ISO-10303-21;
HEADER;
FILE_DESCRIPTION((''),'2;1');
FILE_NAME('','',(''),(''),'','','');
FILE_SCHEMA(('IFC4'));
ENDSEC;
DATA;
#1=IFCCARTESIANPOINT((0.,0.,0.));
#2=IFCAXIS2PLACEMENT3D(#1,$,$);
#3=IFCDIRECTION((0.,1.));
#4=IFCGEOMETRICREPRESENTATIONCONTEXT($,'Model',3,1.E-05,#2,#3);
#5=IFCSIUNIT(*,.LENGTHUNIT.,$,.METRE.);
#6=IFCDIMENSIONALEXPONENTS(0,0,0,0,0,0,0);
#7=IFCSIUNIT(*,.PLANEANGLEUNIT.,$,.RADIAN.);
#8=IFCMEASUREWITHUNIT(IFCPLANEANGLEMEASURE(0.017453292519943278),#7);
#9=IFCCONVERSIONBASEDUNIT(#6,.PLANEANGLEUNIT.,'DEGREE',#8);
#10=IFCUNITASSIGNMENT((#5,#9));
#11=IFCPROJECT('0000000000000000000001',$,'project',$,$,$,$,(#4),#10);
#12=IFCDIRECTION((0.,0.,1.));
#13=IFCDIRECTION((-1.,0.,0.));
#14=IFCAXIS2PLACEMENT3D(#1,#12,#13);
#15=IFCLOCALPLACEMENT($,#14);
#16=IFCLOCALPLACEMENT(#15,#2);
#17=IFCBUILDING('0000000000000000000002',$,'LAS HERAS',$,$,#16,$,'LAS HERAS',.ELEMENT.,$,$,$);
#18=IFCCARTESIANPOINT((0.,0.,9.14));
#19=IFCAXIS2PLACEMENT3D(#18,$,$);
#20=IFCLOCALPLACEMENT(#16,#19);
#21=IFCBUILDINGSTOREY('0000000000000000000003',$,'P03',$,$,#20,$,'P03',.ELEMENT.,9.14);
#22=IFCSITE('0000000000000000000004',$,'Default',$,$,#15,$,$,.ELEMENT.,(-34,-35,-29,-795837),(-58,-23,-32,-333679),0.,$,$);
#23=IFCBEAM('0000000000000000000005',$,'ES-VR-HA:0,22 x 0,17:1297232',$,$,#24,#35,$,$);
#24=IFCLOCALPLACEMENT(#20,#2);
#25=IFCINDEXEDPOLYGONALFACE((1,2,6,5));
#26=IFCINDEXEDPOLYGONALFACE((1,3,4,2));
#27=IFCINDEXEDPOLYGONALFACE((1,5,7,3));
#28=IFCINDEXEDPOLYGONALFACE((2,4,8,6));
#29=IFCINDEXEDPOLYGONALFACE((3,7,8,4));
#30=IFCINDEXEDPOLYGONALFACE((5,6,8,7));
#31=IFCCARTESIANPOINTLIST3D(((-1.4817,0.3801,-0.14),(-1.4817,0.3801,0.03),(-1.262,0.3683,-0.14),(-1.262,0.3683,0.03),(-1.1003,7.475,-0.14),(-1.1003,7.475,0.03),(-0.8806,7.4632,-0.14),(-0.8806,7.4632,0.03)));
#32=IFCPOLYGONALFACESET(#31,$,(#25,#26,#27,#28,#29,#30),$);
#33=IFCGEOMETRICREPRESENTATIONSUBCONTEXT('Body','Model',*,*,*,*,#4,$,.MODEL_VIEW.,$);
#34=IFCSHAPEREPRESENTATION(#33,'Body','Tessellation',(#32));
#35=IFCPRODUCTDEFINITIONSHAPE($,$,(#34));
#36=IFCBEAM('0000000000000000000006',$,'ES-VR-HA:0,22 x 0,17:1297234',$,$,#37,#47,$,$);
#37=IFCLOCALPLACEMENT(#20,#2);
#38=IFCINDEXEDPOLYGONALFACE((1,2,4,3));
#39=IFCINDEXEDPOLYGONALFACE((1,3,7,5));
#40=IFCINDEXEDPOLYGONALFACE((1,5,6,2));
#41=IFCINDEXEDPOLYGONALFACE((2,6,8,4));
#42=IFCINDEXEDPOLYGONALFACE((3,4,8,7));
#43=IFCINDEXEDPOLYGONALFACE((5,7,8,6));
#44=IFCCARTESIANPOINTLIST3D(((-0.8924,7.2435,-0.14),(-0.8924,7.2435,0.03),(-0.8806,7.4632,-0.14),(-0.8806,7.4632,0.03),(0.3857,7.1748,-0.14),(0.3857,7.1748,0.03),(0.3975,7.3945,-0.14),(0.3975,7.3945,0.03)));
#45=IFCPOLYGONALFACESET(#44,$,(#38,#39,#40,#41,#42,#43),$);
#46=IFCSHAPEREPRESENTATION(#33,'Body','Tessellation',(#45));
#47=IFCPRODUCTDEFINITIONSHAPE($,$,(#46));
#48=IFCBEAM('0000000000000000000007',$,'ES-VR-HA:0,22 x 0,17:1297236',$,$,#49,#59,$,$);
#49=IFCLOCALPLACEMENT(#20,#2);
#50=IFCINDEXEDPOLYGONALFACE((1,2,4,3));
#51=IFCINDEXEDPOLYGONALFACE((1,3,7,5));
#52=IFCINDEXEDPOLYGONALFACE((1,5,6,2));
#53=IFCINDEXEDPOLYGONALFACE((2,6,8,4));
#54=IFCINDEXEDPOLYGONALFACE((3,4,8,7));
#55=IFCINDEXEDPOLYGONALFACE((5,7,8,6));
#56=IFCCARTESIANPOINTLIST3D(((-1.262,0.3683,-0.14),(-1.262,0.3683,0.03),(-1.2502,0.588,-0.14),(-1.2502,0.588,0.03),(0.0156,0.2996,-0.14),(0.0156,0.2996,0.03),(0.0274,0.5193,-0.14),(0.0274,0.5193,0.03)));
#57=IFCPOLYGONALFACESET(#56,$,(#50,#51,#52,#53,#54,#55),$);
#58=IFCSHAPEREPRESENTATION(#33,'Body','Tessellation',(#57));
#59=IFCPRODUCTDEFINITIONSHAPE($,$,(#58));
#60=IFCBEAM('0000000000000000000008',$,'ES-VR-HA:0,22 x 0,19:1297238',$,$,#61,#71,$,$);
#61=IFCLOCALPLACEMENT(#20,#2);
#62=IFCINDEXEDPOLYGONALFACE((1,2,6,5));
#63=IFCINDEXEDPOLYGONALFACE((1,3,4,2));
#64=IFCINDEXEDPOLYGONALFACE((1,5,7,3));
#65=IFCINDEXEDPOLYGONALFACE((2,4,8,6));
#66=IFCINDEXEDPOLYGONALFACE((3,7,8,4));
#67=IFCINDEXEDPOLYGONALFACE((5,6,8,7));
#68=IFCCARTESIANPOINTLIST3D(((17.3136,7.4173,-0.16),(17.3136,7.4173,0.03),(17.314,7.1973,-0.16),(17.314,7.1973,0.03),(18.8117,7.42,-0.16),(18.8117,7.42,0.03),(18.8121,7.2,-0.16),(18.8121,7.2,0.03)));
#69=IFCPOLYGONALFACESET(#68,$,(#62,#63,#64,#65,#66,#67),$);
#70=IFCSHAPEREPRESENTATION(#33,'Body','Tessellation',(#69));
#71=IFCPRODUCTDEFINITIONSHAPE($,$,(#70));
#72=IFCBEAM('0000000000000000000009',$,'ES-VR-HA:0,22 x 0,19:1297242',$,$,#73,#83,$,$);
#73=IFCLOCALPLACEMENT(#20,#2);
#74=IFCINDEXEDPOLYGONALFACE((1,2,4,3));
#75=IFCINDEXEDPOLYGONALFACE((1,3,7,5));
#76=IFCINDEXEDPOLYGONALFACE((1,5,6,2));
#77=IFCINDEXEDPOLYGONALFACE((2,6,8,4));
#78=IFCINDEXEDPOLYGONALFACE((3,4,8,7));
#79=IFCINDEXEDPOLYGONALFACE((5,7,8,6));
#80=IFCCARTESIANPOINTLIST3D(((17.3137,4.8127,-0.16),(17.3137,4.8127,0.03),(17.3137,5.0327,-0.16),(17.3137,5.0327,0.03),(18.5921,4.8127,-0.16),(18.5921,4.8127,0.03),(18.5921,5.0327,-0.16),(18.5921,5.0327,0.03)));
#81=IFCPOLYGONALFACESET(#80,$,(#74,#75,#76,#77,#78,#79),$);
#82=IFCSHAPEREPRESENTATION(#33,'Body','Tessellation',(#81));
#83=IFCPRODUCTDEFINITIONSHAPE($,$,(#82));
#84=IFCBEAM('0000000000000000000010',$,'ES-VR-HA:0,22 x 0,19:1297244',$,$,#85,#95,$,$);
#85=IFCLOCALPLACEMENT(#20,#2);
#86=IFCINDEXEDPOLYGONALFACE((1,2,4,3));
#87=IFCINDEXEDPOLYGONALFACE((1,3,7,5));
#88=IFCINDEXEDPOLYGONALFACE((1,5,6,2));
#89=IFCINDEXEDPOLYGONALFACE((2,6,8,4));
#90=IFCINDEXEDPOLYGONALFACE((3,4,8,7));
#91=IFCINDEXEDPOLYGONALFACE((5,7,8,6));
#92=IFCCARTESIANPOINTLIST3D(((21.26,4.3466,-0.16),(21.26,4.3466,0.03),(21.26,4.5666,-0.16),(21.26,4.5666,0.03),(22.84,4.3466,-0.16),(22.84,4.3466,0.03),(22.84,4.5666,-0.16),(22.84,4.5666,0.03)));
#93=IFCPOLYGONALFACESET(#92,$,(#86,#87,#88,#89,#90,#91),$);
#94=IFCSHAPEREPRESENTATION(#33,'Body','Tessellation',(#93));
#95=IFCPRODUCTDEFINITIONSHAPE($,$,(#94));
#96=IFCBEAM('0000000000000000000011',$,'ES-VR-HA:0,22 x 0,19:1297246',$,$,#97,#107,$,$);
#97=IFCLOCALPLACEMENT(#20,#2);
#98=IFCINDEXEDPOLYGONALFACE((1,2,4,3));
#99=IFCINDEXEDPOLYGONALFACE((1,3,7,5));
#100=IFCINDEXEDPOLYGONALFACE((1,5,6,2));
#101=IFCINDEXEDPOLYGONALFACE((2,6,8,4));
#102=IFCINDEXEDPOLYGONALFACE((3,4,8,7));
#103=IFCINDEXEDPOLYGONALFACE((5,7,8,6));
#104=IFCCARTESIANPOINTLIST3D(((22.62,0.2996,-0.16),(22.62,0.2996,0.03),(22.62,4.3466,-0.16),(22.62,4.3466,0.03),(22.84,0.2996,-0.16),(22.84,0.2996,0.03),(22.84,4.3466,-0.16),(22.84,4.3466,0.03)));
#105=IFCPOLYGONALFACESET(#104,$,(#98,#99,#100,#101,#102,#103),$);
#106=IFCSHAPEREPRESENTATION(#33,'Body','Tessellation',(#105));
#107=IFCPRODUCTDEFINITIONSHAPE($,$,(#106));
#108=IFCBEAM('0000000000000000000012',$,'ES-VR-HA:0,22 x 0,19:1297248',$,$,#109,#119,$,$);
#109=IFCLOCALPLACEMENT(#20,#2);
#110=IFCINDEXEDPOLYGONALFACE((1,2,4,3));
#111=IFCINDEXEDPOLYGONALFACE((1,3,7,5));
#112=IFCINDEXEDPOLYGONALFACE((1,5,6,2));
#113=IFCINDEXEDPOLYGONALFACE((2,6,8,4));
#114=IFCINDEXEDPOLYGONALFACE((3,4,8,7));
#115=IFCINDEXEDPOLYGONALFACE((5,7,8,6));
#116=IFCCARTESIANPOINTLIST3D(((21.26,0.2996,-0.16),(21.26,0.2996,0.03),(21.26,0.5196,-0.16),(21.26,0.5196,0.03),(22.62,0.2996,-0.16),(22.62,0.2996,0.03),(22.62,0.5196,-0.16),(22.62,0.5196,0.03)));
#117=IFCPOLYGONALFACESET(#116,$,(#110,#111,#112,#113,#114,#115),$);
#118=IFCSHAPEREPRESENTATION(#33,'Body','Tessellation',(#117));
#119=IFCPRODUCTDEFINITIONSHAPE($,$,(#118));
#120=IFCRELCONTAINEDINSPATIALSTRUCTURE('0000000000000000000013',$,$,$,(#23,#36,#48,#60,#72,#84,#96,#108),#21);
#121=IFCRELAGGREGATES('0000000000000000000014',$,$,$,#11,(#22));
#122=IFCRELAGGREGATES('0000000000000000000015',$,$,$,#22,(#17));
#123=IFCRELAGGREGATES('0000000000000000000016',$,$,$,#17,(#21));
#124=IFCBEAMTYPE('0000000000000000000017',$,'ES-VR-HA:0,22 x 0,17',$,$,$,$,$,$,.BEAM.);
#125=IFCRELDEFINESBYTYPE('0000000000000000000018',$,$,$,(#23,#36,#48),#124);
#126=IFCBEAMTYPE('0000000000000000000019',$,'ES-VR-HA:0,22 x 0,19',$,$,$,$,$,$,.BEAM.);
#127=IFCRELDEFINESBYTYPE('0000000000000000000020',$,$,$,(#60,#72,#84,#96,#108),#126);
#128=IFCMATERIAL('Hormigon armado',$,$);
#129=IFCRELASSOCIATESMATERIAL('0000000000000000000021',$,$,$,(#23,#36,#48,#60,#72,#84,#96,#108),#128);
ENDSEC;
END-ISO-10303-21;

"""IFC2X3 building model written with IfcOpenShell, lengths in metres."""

from ifc_helpers import new_model, entity, si_unit, converted_unit, direction, frame, frame_2d, origin, origin_2d_with_axis, place, context, subcontext, project, spatial, rectangle, extrude, material, type_object, element, save


model = new_model("IFC2X3")

# Units and contexts
model_context = context("Model", 3, precision=1e-05, world=origin(), true_north=direction((0.0, 1.0)))
body_context = subcontext(model_context, "Body", "Model", "MODEL_VIEW")
ifc_project = project(units=[si_unit("LENGTHUNIT", "METRE"), converted_unit("PLANEANGLEUNIT", "DEGREE", entity("IfcPlaneAngleMeasure", 0.017453292519943278), si_unit("PLANEANGLEUNIT", "RADIAN"), dimensions=[0, 0, 0, 0, 0, 0, 0])], contexts=[model_context])

# Site, building, storey
site_placement = place(None, frame((0.0, 0.0, 0.0), z_axis=(0.0, 0.0, 1.0), x_axis=(-1.0, 0.0, 0.0)))
site = spatial("IfcSite", under=ifc_project, at=site_placement, Name="Default", CompositionType="ELEMENT", RefLatitude=(-34, -35, -29, -795837), RefLongitude=(-58, -23, -32, -333679), RefElevation=0.0)
building_placement = place(site_placement, origin())
building = spatial("IfcBuilding", under=site, at=building_placement, Name="LAS HERAS", LongName="LAS HERAS", CompositionType="ELEMENT")
storey_placement = place(building_placement, frame((0.0, 0.0, 9.14)))
storey = spatial("IfcBuildingStorey", under=building, at=storey_placement, Name="P03", LongName="P03", CompositionType="ELEMENT", Elevation=9.14)

# Beams
ifc_material = material(Name="Hormigon armado")
beam_type_1 = type_object("IfcBeamType", Name="ES-VR-HA:0,22 x 0,17", PredefinedType="BEAM")
beam_1_placement = place(storey_placement, frame((-0.9963, 7.3593, 0.03), z_axis=(0.0, 0.0, 1.0), x_axis=(-0.05369, -0.998558, 0.0)))
element("IfcBeam", 1, at=beam_1_placement, inside=storey, type_object=beam_type_1, material=ifc_material, Name="ES-VR-HA:0,22 x 0,17:1297232", context=body_context, shape_type="SweptSolid", body=[
    extrude(rectangle(XDim=0.17, YDim=0.22, at=frame_2d((0.0, 0.0), x_axis=(1.0, 0.0))), frame((-0.11, 0.0, -0.085), z_axis=(1.0, 0.0, 0.0), x_axis=(0.0, 0.0, -1.0)), (0.0, 0.0, 1.0), 7.1052),
])
beam_2_placement = place(storey_placement, frame((0.3916, 7.2846, 0.03), z_axis=(0.0, 0.0, 1.0), x_axis=(-0.998558, 0.05368, 0.0)))
element("IfcBeam", 2, at=beam_2_placement, inside=storey, type_object=beam_type_1, material=ifc_material, Name="ES-VR-HA:0,22 x 0,17:1297234", context=body_context, shape_type="SweptSolid", body=[
    extrude(rectangle(XDim=0.17, YDim=0.22, at=frame_2d((0.0, 0.0), x_axis=(1.0, 0.0))), frame((0.0, 0.0, -0.085), z_axis=(1.0, 0.0, 0.0), x_axis=(0.0, 0.0, -1.0)), (0.0, 0.0, 1.0), 1.28),
])
beam_3_placement = place(storey_placement, frame((0.0215, 0.4094, 0.03), z_axis=(0.0, 0.0, 1.0), x_axis=(-0.998558, 0.05369, 0.0)))
element("IfcBeam", 3, at=beam_3_placement, inside=storey, type_object=beam_type_1, material=ifc_material, Name="ES-VR-HA:0,22 x 0,17:1297236", context=body_context, shape_type="SweptSolid", body=[
    extrude(rectangle(XDim=0.17, YDim=0.22, at=origin_2d_with_axis()), frame((0.0, 0.0, -0.085), z_axis=(1.0, 0.0, 0.0), x_axis=(0.0, 0.0, -1.0)), (0.0, 0.0, 1.0), 1.2795),
])
beam_type_2 = type_object("IfcBeamType", Name="ES-VR-HA:0,22 x 0,19", PredefinedType="BEAM")
beam_4_placement = place(storey_placement, frame((17.3138, 7.3073, 0.03), z_axis=(0.0, 0.0, 1.0), x_axis=(0.999998, 0.001781, 0.0)))
element("IfcBeam", 4, at=beam_4_placement, inside=storey, type_object=beam_type_2, material=ifc_material, Name="ES-VR-HA:0,22 x 0,19:1297238", context=body_context, shape_type="SweptSolid", body=[
    extrude(rectangle(XDim=0.19, YDim=0.22, at=frame_2d((0.0, 0.0), x_axis=(1.0, 0.0))), frame((0.0, 0.0, -0.095), z_axis=(1.0, 0.0, 0.0), x_axis=(0.0, 0.0, -1.0)), (0.0, 0.0, 1.0), 1.4981),
])
beam_5_placement = place(storey_placement, frame((17.3137, 4.9227, 0.03)))
element("IfcBeam", 5, at=beam_5_placement, inside=storey, type_object=beam_type_2, material=ifc_material, Name="ES-VR-HA:0,22 x 0,19:1297242", context=body_context, shape_type="SweptSolid", body=[
    extrude(rectangle(XDim=0.19, YDim=0.22, at=frame_2d((0.0, 0.0), x_axis=(1.0, 0.0))), frame((0.0, 0.0, -0.095), z_axis=(1.0, 0.0, 0.0), x_axis=(0.0, 0.0, -1.0)), (0.0, 0.0, 1.0), 1.2784),
])
beam_6_placement = place(storey_placement, frame((21.26, 4.4566, 0.03)))
element("IfcBeam", 6, at=beam_6_placement, inside=storey, type_object=beam_type_2, material=ifc_material, Name="ES-VR-HA:0,22 x 0,19:1297244", context=body_context, shape_type="SweptSolid", body=[
    extrude(rectangle(XDim=0.19, YDim=0.22, at=origin_2d_with_axis()), frame((0.0, 0.0, -0.095), z_axis=(1.0, 0.0, 0.0), x_axis=(0.0, 0.0, -1.0)), (0.0, 0.0, 1.0), 1.58),
])
beam_7_placement = place(storey_placement, frame((22.73, 4.4566, 0.03), z_axis=(0.0, 0.0, 1.0), x_axis=(0.0, -1.0, 0.0)))
element("IfcBeam", 7, at=beam_7_placement, inside=storey, type_object=beam_type_2, material=ifc_material, Name="ES-VR-HA:0,22 x 0,19:1297246", context=body_context, shape_type="SweptSolid", body=[
    extrude(rectangle(XDim=0.19, YDim=0.22, at=frame_2d((0.0, 0.0), x_axis=(1.0, 0.0))), frame((0.11, 0.0, -0.095), z_axis=(1.0, 0.0, 0.0), x_axis=(0.0, 0.0, -1.0)), (0.0, 0.0, 1.0), 4.0471),
])
beam_8_placement = place(storey_placement, frame((21.26, 0.4096, 0.03)))
element("IfcBeam", 8, at=beam_8_placement, inside=storey, type_object=beam_type_2, material=ifc_material, Name="ES-VR-HA:0,22 x 0,19:1297248", context=body_context, shape_type="SweptSolid", body=[
    extrude(rectangle(XDim=0.19, YDim=0.22, at=frame_2d((0.0, 0.0), x_axis=(1.0, 0.0))), frame((0.0, 0.0, -0.095), z_axis=(1.0, 0.0, 0.0), x_axis=(0.0, 0.0, -1.0)), (0.0, 0.0, 1.0), 1.36),
])

save(model, "model.ifc")
